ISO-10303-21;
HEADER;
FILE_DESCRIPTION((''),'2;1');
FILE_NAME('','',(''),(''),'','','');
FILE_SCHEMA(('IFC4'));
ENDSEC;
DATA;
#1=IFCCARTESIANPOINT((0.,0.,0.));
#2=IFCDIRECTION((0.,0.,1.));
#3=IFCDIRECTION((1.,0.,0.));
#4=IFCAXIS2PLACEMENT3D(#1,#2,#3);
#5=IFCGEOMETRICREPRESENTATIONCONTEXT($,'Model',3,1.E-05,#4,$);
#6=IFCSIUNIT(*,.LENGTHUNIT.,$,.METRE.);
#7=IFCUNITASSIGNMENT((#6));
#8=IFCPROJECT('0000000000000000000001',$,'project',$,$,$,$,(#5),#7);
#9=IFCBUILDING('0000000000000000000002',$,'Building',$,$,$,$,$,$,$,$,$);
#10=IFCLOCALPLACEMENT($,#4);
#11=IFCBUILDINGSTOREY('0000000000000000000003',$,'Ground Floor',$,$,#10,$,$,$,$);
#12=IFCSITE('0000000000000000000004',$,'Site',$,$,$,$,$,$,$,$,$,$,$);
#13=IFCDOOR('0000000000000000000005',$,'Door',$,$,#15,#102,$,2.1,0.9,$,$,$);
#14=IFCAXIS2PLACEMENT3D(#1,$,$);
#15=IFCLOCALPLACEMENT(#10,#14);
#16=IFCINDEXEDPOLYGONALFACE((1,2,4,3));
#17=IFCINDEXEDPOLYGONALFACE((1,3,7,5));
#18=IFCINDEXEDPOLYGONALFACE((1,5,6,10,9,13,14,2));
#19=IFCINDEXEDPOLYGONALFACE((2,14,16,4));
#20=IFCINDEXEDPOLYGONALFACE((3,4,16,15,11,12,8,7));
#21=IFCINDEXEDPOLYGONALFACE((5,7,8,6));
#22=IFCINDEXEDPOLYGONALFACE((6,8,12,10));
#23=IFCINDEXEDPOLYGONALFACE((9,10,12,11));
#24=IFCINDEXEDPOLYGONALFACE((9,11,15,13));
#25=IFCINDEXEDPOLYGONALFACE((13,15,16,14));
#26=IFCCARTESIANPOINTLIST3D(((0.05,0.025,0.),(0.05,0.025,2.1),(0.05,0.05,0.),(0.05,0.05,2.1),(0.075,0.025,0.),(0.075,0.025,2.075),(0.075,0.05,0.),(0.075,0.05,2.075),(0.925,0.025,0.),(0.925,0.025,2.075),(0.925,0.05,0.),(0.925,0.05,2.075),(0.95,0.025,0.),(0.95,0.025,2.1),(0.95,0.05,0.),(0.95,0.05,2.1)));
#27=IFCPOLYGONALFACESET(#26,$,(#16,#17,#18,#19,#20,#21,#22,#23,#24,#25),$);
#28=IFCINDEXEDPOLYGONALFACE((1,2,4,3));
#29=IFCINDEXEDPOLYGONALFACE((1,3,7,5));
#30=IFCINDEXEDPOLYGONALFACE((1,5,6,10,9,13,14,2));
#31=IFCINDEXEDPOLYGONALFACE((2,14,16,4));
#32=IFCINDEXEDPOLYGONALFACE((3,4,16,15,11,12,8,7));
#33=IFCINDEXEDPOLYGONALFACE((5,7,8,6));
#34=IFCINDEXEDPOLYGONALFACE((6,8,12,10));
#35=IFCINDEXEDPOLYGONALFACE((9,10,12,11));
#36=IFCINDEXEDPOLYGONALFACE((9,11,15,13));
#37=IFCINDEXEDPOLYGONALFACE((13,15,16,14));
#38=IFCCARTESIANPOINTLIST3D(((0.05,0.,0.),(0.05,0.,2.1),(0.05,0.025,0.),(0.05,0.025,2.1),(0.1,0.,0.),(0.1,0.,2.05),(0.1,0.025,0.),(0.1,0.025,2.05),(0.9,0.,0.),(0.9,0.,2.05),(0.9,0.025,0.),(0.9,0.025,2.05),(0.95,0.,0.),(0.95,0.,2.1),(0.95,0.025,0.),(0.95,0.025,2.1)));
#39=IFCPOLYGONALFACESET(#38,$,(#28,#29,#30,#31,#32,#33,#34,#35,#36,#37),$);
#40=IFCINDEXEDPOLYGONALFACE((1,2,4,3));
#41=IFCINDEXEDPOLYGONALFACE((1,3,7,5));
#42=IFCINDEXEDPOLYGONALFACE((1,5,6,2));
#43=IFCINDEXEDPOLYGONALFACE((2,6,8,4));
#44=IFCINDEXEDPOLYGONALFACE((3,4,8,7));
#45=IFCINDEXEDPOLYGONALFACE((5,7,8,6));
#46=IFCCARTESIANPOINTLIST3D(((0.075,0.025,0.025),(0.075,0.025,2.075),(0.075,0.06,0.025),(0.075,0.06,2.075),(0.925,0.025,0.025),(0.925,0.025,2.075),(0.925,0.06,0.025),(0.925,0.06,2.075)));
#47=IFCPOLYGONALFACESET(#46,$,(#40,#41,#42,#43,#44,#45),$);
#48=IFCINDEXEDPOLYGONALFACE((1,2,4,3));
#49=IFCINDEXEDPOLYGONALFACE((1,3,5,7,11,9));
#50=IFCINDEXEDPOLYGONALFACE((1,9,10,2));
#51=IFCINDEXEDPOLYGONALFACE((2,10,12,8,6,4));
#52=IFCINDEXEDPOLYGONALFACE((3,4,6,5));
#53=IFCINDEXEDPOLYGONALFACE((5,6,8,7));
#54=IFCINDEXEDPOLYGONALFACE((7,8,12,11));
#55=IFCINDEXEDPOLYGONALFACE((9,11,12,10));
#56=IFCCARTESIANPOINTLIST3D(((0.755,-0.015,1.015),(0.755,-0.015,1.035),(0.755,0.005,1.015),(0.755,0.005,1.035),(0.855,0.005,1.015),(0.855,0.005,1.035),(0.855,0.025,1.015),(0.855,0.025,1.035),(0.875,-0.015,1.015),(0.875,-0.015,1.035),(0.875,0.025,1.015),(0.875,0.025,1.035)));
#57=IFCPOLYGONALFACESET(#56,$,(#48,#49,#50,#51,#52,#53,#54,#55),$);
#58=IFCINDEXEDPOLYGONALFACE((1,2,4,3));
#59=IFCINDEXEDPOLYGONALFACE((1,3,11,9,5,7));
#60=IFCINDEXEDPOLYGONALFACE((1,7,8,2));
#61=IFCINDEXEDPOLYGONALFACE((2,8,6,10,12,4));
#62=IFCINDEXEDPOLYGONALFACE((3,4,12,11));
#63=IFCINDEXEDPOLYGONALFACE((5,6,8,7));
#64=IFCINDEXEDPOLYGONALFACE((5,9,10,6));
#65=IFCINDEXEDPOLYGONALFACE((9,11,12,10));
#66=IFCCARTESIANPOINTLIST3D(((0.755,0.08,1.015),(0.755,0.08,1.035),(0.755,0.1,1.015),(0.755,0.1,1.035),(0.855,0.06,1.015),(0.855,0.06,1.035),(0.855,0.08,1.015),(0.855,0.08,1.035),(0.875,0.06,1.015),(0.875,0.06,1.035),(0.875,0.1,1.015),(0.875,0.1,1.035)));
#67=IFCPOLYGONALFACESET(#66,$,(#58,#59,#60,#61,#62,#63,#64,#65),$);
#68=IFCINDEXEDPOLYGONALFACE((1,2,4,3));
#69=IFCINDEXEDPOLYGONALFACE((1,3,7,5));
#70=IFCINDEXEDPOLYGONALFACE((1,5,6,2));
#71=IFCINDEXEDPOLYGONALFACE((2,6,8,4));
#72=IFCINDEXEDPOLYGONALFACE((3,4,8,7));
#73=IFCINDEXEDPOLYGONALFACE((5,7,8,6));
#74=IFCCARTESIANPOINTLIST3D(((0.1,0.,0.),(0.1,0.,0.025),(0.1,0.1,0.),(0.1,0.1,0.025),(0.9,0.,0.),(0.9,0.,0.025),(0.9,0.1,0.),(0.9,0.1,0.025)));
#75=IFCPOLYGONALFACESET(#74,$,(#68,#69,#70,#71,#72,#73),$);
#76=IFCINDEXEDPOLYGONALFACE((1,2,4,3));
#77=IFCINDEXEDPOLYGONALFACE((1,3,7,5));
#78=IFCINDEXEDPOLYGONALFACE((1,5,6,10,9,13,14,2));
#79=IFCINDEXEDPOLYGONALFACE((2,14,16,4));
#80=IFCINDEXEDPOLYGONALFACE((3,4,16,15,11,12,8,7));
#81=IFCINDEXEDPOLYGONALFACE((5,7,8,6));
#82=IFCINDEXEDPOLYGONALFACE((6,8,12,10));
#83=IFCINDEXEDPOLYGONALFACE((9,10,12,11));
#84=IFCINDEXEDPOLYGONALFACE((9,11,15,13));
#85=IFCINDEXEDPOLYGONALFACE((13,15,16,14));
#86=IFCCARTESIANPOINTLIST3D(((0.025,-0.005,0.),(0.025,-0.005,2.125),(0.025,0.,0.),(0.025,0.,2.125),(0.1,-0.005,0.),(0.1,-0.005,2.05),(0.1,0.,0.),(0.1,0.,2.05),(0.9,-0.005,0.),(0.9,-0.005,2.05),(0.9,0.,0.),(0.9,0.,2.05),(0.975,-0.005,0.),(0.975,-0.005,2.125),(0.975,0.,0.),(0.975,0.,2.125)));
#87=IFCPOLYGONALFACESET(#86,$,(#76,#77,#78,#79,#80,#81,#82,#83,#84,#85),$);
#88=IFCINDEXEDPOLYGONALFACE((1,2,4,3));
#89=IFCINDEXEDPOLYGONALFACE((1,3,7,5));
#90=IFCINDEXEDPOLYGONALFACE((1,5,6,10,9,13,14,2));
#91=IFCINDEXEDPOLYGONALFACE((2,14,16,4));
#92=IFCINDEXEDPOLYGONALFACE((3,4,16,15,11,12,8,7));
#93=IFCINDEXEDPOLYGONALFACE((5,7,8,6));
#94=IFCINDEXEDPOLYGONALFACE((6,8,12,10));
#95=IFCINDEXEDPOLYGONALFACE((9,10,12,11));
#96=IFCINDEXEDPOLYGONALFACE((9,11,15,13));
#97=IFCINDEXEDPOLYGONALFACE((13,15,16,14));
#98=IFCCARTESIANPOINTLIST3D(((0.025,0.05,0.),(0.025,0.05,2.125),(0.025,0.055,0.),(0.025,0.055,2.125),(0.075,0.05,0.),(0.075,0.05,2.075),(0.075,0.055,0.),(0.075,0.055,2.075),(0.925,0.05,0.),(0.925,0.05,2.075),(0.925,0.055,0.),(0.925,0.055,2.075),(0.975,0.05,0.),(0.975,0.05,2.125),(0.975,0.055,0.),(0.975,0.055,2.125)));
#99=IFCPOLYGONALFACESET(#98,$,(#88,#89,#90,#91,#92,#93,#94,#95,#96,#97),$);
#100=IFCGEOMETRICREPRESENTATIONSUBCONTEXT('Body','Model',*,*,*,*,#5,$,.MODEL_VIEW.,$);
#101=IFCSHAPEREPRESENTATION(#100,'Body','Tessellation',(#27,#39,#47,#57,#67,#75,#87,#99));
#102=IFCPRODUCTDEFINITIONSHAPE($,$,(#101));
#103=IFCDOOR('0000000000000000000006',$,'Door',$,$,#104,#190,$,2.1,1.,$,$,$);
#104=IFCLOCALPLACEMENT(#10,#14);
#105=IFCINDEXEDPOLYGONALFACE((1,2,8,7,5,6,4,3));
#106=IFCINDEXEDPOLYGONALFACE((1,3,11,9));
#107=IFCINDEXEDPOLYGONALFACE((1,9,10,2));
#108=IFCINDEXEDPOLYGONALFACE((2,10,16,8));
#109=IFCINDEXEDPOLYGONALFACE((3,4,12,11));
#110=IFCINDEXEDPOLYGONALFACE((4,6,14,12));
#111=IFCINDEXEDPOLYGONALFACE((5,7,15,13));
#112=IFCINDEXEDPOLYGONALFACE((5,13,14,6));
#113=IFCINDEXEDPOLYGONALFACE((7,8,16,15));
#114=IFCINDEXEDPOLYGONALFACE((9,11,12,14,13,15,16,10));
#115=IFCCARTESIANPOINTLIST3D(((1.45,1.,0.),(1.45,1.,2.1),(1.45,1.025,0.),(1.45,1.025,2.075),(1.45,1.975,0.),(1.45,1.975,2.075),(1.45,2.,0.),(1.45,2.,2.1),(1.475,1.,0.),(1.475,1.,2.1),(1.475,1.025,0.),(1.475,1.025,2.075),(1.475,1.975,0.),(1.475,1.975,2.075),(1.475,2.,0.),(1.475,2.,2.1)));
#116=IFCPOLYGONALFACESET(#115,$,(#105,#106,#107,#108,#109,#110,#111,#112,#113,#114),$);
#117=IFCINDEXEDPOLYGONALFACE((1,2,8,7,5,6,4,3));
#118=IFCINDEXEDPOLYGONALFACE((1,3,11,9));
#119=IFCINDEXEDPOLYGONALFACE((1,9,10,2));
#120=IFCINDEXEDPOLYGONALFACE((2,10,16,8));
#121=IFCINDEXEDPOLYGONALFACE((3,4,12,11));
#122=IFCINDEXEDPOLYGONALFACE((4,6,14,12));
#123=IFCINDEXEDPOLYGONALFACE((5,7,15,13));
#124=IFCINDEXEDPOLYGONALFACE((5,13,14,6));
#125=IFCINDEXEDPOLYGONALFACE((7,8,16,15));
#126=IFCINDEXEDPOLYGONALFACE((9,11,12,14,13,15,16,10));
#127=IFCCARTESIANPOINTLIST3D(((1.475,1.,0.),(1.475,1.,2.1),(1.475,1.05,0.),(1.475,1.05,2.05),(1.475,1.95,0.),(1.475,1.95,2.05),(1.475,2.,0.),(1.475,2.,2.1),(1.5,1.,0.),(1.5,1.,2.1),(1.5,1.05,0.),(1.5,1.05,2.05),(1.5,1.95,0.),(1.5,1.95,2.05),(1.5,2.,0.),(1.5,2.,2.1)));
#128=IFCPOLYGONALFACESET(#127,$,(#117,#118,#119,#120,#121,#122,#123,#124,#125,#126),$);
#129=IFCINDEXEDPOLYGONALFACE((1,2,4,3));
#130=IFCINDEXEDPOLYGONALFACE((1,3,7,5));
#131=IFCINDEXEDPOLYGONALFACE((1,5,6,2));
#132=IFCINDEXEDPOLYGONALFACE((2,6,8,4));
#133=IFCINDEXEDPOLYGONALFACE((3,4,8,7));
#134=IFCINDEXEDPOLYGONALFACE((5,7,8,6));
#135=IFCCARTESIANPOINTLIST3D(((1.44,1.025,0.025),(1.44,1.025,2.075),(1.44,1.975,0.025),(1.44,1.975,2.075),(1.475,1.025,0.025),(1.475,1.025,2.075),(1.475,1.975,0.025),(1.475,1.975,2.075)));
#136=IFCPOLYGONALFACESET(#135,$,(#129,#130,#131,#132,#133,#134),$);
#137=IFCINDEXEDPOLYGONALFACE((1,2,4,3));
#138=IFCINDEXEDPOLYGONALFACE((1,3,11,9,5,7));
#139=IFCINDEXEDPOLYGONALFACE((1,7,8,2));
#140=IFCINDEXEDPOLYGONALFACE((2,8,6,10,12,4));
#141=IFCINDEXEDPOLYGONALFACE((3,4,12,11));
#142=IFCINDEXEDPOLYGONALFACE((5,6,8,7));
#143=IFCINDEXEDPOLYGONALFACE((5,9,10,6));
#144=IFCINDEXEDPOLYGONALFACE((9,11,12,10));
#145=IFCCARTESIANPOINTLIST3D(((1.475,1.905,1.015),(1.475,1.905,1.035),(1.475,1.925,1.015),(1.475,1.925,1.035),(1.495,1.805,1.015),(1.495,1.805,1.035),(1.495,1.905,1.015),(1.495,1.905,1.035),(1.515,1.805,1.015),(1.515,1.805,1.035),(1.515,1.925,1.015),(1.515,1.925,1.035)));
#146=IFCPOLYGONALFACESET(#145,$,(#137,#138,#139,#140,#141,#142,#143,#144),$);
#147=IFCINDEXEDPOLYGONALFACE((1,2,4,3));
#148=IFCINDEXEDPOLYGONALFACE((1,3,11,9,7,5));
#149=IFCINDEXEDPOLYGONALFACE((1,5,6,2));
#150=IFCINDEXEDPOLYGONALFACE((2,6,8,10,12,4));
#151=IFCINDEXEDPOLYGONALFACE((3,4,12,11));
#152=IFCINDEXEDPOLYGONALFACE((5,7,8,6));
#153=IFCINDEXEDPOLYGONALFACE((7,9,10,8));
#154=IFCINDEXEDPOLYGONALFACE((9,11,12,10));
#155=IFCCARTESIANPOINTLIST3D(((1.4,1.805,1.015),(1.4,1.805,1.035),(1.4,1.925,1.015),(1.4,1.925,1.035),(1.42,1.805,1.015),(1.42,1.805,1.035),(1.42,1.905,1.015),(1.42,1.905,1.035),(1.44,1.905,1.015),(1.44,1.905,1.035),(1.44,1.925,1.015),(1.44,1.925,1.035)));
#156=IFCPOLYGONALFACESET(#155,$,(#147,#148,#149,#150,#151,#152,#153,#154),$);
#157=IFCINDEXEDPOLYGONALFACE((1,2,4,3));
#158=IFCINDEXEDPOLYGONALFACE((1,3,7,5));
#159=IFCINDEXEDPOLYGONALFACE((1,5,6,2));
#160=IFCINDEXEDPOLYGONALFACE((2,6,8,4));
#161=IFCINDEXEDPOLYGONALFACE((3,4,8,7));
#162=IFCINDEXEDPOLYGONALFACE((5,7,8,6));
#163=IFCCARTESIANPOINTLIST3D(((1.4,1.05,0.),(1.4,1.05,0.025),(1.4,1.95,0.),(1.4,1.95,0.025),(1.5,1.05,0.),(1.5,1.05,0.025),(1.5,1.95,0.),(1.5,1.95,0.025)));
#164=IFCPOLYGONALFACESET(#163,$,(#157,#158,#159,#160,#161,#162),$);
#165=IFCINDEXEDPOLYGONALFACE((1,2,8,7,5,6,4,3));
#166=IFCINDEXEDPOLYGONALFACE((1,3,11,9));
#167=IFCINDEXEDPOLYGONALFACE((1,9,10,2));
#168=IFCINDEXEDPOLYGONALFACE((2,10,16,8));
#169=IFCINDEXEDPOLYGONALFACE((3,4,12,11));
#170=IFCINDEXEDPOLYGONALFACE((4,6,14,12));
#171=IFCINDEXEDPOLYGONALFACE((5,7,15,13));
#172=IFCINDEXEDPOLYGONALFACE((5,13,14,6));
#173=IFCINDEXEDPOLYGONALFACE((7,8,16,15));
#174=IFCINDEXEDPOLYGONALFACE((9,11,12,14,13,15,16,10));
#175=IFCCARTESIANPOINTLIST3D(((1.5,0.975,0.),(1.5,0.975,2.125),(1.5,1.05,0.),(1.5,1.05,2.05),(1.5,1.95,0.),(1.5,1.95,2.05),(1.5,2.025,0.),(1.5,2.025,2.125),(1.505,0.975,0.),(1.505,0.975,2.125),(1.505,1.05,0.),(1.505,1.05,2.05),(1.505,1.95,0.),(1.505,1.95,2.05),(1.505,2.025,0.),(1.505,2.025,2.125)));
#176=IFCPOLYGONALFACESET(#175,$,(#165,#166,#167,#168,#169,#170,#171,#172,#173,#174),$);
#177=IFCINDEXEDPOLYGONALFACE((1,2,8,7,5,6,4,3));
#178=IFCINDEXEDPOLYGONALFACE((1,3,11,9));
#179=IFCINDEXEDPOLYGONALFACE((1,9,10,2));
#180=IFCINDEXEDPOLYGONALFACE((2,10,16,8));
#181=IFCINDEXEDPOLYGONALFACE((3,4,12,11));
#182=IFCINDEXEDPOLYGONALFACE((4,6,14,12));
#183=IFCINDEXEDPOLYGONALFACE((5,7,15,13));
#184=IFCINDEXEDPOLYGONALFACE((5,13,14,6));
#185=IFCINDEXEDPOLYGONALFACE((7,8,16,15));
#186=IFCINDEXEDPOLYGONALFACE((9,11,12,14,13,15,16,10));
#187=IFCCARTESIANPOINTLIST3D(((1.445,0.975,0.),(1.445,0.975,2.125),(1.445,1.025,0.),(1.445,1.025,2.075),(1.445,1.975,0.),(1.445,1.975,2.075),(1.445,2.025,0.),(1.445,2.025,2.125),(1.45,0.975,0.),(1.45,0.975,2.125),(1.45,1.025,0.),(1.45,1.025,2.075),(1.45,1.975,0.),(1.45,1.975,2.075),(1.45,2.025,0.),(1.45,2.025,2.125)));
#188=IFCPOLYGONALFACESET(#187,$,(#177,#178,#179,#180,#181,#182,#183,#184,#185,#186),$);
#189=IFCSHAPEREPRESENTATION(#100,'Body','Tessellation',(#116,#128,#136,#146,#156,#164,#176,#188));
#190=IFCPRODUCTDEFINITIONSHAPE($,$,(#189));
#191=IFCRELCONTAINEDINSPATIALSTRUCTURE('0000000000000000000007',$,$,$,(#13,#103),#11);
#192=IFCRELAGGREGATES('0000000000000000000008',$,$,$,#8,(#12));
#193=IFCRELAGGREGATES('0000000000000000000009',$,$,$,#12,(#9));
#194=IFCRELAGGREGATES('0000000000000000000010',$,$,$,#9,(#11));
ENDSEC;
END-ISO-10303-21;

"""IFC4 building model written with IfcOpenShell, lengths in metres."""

from ifc_helpers import new_model, si_unit, frame, origin_with_axes, place, context, subcontext, project, spatial, line, indexed_curve, outline, extrude, element, save


model = new_model("IFC4")

# Units and contexts
model_context = context("Model", 3, precision=1e-05, world=origin_with_axes())
body_context = subcontext(model_context, "Body", "Model", "MODEL_VIEW")
ifc_project = project(units=[si_unit("LENGTHUNIT", "METRE")], contexts=[model_context])

# Site, building, storey
site = spatial("IfcSite", under=ifc_project, Name="Site")
building = spatial("IfcBuilding", under=site, Name="Building")
storey_placement = place(None, origin_with_axes())
storey = spatial("IfcBuildingStorey", under=building, at=storey_placement, Name="Ground Floor")

# Doors
door_1_placement = place(storey_placement, frame((0.05, 0.0, 0.0), z_axis=(0.0, 0.0, 1.0), x_axis=(1.0, 0.0, 0.0)))
element("IfcDoor", 1, at=door_1_placement, inside=storey, Name="Door", OverallHeight=2.1, OverallWidth=0.9, context=body_context, shape_type="SweptSolid", body=[
    extrude(outline(indexed_curve([(0.0, 0.0), (0.0, 2.1), (0.9, 2.1), (0.9, 0.0), (0.875, 0.0), (0.875, 2.075), (0.025, 2.075), (0.025, 0.0)], segments=[line(1, 2, 3, 4, 5, 6, 7, 8, 1)])), frame((0.0, 0.025, 0.0), z_axis=(0.0, -1.0, 0.0), x_axis=(1.0, 0.0, 0.0)), (0.0, 0.0, -1.0), 0.025),
    extrude(outline(indexed_curve([(0.0, 0.0), (0.0, 2.1), (0.9, 2.1), (0.9, 0.0), (0.85, 0.0), (0.85, 2.05), (0.05, 2.05), (0.05, 0.0)], segments=[line(1, 2, 3, 4, 5, 6, 7, 8, 1)])), frame((0.0, 0.0, 0.0), z_axis=(0.0, -1.0, 0.0), x_axis=(1.0, 0.0, 0.0)), (0.0, 0.0, -1.0), 0.025),
    extrude(outline(indexed_curve([(0.0, 0.0), (0.85, 0.0), (0.85, 0.035), (0.0, 0.035)], segments=[line(1, 2, 3, 4, 1)])), frame((0.025, 0.025, 0.025), z_axis=(0.0, 0.0, 1.0), x_axis=(1.0, 0.0, 0.0)), (0.0, 0.0, 1.0), 2.05),
    extrude(outline(indexed_curve([(0.0, 0.0), (0.0, -0.04), (-0.12, -0.04), (-0.12, -0.02), (-0.02, -0.02), (-0.02, 0.0)], segments=[line(1, 2, 3, 4, 5, 6, 1)])), frame((0.825, 0.025, 1.015), z_axis=(0.0, 0.0, 1.0), x_axis=(1.0, 0.0, 0.0)), (0.0, 0.0, 1.0), 0.02),
    extrude(outline(indexed_curve([(0.0, 0.0), (0.0, 0.04), (-0.12, 0.04), (-0.12, 0.02), (-0.02, 0.02), (-0.02, 0.0)], segments=[line(1, 2, 3, 4, 5, 6, 1)])), frame((0.825, 0.06, 1.015), z_axis=(0.0, 0.0, 1.0), x_axis=(1.0, 0.0, 0.0)), (0.0, 0.0, 1.0), 0.02),
    extrude(outline(indexed_curve([(0.0, 0.0), (0.8, 0.0), (0.8, 0.1), (0.0, 0.1)], segments=[line(1, 2, 3, 4, 1)])), frame((0.05, 0.0, 0.0), z_axis=(0.0, 0.0, 1.0), x_axis=(1.0, 0.0, 0.0)), (0.0, 0.0, 1.0), 0.025),
    extrude(outline(indexed_curve([(0.0, 0.0), (0.0, 2.125), (0.95, 2.125), (0.95, 0.0), (0.875, 0.0), (0.875, 2.05), (0.075, 2.05), (0.075, 0.0)], segments=[line(1, 2, 3, 4, 5, 6, 7, 8, 1)])), frame((-0.025, -0.005, 0.0), z_axis=(0.0, -1.0, 0.0), x_axis=(1.0, 0.0, 0.0)), (0.0, 0.0, -1.0), 0.005),
    extrude(outline(indexed_curve([(0.0, 0.0), (0.0, 2.125), (0.95, 2.125), (0.95, 0.0), (0.9, 0.0), (0.9, 2.075), (0.05, 2.075), (0.05, 0.0)], segments=[line(1, 2, 3, 4, 5, 6, 7, 8, 1)])), frame((-0.025, 0.05, 0.0), z_axis=(0.0, -1.0, 0.0), x_axis=(1.0, 0.0, 0.0)), (0.0, 0.0, -1.0), 0.005),
])
door_2_placement = place(storey_placement, frame((1.5, 1.0, 0.0), z_axis=(0.0, 0.0, 1.0), x_axis=(0.0, 1.0, 0.0)))
element("IfcDoor", 2, at=door_2_placement, inside=storey, Name="Door", OverallHeight=2.1, OverallWidth=1.0, context=body_context, shape_type="SweptSolid", body=[
    extrude(outline(indexed_curve([(0.0, 0.0), (0.0, 2.1), (1.0, 2.1), (1.0, 0.0), (0.975, 0.0), (0.975, 2.075), (0.025, 2.075), (0.025, 0.0)], segments=[line(1, 2, 3, 4, 5, 6, 7, 8, 1)])), frame((0.0, 0.025, 0.0), z_axis=(0.0, -1.0, 0.0), x_axis=(1.0, 0.0, 0.0)), (0.0, 0.0, -1.0), 0.025),
    extrude(outline(indexed_curve([(0.0, 0.0), (0.0, 2.1), (1.0, 2.1), (1.0, 0.0), (0.95, 0.0), (0.95, 2.05), (0.05, 2.05), (0.05, 0.0)], segments=[line(1, 2, 3, 4, 5, 6, 7, 8, 1)])), frame((0.0, 0.0, 0.0), z_axis=(0.0, -1.0, 0.0), x_axis=(1.0, 0.0, 0.0)), (0.0, 0.0, -1.0), 0.025),
    extrude(outline(indexed_curve([(0.0, 0.0), (0.95, 0.0), (0.95, 0.035), (0.0, 0.035)], segments=[line(1, 2, 3, 4, 1)])), frame((0.025, 0.025, 0.025), z_axis=(0.0, 0.0, 1.0), x_axis=(1.0, 0.0, 0.0)), (0.0, 0.0, 1.0), 2.05),
    extrude(outline(indexed_curve([(0.0, 0.0), (0.0, -0.04), (-0.12, -0.04), (-0.12, -0.02), (-0.02, -0.02), (-0.02, 0.0)], segments=[line(1, 2, 3, 4, 5, 6, 1)])), frame((0.925, 0.025, 1.015), z_axis=(0.0, 0.0, 1.0), x_axis=(1.0, 0.0, 0.0)), (0.0, 0.0, 1.0), 0.02),
    extrude(outline(indexed_curve([(0.0, 0.0), (0.0, 0.04), (-0.12, 0.04), (-0.12, 0.02), (-0.02, 0.02), (-0.02, 0.0)], segments=[line(1, 2, 3, 4, 5, 6, 1)])), frame((0.925, 0.06, 1.015), z_axis=(0.0, 0.0, 1.0), x_axis=(1.0, 0.0, 0.0)), (0.0, 0.0, 1.0), 0.02),
    extrude(outline(indexed_curve([(0.0, 0.0), (0.9, 0.0), (0.9, 0.1), (0.0, 0.1)], segments=[line(1, 2, 3, 4, 1)])), frame((0.05, 0.0, 0.0), z_axis=(0.0, 0.0, 1.0), x_axis=(1.0, 0.0, 0.0)), (0.0, 0.0, 1.0), 0.025),
    extrude(outline(indexed_curve([(0.0, 0.0), (0.0, 2.125), (1.05, 2.125), (1.05, 0.0), (0.975, 0.0), (0.975, 2.05), (0.075, 2.05), (0.075, 0.0)], segments=[line(1, 2, 3, 4, 5, 6, 7, 8, 1)])), frame((-0.025, -0.005, 0.0), z_axis=(0.0, -1.0, 0.0), x_axis=(1.0, 0.0, 0.0)), (0.0, 0.0, -1.0), 0.005),
    extrude(outline(indexed_curve([(0.0, 0.0), (0.0, 2.125), (1.05, 2.125), (1.05, 0.0), (1.0, 0.0), (1.0, 2.075), (0.05, 2.075), (0.05, 0.0)], segments=[line(1, 2, 3, 4, 5, 6, 7, 8, 1)])), frame((-0.025, 0.05, 0.0), z_axis=(0.0, -1.0, 0.0), x_axis=(1.0, 0.0, 0.0)), (0.0, 0.0, -1.0), 0.005),
])

save(model, "model.ifc")
